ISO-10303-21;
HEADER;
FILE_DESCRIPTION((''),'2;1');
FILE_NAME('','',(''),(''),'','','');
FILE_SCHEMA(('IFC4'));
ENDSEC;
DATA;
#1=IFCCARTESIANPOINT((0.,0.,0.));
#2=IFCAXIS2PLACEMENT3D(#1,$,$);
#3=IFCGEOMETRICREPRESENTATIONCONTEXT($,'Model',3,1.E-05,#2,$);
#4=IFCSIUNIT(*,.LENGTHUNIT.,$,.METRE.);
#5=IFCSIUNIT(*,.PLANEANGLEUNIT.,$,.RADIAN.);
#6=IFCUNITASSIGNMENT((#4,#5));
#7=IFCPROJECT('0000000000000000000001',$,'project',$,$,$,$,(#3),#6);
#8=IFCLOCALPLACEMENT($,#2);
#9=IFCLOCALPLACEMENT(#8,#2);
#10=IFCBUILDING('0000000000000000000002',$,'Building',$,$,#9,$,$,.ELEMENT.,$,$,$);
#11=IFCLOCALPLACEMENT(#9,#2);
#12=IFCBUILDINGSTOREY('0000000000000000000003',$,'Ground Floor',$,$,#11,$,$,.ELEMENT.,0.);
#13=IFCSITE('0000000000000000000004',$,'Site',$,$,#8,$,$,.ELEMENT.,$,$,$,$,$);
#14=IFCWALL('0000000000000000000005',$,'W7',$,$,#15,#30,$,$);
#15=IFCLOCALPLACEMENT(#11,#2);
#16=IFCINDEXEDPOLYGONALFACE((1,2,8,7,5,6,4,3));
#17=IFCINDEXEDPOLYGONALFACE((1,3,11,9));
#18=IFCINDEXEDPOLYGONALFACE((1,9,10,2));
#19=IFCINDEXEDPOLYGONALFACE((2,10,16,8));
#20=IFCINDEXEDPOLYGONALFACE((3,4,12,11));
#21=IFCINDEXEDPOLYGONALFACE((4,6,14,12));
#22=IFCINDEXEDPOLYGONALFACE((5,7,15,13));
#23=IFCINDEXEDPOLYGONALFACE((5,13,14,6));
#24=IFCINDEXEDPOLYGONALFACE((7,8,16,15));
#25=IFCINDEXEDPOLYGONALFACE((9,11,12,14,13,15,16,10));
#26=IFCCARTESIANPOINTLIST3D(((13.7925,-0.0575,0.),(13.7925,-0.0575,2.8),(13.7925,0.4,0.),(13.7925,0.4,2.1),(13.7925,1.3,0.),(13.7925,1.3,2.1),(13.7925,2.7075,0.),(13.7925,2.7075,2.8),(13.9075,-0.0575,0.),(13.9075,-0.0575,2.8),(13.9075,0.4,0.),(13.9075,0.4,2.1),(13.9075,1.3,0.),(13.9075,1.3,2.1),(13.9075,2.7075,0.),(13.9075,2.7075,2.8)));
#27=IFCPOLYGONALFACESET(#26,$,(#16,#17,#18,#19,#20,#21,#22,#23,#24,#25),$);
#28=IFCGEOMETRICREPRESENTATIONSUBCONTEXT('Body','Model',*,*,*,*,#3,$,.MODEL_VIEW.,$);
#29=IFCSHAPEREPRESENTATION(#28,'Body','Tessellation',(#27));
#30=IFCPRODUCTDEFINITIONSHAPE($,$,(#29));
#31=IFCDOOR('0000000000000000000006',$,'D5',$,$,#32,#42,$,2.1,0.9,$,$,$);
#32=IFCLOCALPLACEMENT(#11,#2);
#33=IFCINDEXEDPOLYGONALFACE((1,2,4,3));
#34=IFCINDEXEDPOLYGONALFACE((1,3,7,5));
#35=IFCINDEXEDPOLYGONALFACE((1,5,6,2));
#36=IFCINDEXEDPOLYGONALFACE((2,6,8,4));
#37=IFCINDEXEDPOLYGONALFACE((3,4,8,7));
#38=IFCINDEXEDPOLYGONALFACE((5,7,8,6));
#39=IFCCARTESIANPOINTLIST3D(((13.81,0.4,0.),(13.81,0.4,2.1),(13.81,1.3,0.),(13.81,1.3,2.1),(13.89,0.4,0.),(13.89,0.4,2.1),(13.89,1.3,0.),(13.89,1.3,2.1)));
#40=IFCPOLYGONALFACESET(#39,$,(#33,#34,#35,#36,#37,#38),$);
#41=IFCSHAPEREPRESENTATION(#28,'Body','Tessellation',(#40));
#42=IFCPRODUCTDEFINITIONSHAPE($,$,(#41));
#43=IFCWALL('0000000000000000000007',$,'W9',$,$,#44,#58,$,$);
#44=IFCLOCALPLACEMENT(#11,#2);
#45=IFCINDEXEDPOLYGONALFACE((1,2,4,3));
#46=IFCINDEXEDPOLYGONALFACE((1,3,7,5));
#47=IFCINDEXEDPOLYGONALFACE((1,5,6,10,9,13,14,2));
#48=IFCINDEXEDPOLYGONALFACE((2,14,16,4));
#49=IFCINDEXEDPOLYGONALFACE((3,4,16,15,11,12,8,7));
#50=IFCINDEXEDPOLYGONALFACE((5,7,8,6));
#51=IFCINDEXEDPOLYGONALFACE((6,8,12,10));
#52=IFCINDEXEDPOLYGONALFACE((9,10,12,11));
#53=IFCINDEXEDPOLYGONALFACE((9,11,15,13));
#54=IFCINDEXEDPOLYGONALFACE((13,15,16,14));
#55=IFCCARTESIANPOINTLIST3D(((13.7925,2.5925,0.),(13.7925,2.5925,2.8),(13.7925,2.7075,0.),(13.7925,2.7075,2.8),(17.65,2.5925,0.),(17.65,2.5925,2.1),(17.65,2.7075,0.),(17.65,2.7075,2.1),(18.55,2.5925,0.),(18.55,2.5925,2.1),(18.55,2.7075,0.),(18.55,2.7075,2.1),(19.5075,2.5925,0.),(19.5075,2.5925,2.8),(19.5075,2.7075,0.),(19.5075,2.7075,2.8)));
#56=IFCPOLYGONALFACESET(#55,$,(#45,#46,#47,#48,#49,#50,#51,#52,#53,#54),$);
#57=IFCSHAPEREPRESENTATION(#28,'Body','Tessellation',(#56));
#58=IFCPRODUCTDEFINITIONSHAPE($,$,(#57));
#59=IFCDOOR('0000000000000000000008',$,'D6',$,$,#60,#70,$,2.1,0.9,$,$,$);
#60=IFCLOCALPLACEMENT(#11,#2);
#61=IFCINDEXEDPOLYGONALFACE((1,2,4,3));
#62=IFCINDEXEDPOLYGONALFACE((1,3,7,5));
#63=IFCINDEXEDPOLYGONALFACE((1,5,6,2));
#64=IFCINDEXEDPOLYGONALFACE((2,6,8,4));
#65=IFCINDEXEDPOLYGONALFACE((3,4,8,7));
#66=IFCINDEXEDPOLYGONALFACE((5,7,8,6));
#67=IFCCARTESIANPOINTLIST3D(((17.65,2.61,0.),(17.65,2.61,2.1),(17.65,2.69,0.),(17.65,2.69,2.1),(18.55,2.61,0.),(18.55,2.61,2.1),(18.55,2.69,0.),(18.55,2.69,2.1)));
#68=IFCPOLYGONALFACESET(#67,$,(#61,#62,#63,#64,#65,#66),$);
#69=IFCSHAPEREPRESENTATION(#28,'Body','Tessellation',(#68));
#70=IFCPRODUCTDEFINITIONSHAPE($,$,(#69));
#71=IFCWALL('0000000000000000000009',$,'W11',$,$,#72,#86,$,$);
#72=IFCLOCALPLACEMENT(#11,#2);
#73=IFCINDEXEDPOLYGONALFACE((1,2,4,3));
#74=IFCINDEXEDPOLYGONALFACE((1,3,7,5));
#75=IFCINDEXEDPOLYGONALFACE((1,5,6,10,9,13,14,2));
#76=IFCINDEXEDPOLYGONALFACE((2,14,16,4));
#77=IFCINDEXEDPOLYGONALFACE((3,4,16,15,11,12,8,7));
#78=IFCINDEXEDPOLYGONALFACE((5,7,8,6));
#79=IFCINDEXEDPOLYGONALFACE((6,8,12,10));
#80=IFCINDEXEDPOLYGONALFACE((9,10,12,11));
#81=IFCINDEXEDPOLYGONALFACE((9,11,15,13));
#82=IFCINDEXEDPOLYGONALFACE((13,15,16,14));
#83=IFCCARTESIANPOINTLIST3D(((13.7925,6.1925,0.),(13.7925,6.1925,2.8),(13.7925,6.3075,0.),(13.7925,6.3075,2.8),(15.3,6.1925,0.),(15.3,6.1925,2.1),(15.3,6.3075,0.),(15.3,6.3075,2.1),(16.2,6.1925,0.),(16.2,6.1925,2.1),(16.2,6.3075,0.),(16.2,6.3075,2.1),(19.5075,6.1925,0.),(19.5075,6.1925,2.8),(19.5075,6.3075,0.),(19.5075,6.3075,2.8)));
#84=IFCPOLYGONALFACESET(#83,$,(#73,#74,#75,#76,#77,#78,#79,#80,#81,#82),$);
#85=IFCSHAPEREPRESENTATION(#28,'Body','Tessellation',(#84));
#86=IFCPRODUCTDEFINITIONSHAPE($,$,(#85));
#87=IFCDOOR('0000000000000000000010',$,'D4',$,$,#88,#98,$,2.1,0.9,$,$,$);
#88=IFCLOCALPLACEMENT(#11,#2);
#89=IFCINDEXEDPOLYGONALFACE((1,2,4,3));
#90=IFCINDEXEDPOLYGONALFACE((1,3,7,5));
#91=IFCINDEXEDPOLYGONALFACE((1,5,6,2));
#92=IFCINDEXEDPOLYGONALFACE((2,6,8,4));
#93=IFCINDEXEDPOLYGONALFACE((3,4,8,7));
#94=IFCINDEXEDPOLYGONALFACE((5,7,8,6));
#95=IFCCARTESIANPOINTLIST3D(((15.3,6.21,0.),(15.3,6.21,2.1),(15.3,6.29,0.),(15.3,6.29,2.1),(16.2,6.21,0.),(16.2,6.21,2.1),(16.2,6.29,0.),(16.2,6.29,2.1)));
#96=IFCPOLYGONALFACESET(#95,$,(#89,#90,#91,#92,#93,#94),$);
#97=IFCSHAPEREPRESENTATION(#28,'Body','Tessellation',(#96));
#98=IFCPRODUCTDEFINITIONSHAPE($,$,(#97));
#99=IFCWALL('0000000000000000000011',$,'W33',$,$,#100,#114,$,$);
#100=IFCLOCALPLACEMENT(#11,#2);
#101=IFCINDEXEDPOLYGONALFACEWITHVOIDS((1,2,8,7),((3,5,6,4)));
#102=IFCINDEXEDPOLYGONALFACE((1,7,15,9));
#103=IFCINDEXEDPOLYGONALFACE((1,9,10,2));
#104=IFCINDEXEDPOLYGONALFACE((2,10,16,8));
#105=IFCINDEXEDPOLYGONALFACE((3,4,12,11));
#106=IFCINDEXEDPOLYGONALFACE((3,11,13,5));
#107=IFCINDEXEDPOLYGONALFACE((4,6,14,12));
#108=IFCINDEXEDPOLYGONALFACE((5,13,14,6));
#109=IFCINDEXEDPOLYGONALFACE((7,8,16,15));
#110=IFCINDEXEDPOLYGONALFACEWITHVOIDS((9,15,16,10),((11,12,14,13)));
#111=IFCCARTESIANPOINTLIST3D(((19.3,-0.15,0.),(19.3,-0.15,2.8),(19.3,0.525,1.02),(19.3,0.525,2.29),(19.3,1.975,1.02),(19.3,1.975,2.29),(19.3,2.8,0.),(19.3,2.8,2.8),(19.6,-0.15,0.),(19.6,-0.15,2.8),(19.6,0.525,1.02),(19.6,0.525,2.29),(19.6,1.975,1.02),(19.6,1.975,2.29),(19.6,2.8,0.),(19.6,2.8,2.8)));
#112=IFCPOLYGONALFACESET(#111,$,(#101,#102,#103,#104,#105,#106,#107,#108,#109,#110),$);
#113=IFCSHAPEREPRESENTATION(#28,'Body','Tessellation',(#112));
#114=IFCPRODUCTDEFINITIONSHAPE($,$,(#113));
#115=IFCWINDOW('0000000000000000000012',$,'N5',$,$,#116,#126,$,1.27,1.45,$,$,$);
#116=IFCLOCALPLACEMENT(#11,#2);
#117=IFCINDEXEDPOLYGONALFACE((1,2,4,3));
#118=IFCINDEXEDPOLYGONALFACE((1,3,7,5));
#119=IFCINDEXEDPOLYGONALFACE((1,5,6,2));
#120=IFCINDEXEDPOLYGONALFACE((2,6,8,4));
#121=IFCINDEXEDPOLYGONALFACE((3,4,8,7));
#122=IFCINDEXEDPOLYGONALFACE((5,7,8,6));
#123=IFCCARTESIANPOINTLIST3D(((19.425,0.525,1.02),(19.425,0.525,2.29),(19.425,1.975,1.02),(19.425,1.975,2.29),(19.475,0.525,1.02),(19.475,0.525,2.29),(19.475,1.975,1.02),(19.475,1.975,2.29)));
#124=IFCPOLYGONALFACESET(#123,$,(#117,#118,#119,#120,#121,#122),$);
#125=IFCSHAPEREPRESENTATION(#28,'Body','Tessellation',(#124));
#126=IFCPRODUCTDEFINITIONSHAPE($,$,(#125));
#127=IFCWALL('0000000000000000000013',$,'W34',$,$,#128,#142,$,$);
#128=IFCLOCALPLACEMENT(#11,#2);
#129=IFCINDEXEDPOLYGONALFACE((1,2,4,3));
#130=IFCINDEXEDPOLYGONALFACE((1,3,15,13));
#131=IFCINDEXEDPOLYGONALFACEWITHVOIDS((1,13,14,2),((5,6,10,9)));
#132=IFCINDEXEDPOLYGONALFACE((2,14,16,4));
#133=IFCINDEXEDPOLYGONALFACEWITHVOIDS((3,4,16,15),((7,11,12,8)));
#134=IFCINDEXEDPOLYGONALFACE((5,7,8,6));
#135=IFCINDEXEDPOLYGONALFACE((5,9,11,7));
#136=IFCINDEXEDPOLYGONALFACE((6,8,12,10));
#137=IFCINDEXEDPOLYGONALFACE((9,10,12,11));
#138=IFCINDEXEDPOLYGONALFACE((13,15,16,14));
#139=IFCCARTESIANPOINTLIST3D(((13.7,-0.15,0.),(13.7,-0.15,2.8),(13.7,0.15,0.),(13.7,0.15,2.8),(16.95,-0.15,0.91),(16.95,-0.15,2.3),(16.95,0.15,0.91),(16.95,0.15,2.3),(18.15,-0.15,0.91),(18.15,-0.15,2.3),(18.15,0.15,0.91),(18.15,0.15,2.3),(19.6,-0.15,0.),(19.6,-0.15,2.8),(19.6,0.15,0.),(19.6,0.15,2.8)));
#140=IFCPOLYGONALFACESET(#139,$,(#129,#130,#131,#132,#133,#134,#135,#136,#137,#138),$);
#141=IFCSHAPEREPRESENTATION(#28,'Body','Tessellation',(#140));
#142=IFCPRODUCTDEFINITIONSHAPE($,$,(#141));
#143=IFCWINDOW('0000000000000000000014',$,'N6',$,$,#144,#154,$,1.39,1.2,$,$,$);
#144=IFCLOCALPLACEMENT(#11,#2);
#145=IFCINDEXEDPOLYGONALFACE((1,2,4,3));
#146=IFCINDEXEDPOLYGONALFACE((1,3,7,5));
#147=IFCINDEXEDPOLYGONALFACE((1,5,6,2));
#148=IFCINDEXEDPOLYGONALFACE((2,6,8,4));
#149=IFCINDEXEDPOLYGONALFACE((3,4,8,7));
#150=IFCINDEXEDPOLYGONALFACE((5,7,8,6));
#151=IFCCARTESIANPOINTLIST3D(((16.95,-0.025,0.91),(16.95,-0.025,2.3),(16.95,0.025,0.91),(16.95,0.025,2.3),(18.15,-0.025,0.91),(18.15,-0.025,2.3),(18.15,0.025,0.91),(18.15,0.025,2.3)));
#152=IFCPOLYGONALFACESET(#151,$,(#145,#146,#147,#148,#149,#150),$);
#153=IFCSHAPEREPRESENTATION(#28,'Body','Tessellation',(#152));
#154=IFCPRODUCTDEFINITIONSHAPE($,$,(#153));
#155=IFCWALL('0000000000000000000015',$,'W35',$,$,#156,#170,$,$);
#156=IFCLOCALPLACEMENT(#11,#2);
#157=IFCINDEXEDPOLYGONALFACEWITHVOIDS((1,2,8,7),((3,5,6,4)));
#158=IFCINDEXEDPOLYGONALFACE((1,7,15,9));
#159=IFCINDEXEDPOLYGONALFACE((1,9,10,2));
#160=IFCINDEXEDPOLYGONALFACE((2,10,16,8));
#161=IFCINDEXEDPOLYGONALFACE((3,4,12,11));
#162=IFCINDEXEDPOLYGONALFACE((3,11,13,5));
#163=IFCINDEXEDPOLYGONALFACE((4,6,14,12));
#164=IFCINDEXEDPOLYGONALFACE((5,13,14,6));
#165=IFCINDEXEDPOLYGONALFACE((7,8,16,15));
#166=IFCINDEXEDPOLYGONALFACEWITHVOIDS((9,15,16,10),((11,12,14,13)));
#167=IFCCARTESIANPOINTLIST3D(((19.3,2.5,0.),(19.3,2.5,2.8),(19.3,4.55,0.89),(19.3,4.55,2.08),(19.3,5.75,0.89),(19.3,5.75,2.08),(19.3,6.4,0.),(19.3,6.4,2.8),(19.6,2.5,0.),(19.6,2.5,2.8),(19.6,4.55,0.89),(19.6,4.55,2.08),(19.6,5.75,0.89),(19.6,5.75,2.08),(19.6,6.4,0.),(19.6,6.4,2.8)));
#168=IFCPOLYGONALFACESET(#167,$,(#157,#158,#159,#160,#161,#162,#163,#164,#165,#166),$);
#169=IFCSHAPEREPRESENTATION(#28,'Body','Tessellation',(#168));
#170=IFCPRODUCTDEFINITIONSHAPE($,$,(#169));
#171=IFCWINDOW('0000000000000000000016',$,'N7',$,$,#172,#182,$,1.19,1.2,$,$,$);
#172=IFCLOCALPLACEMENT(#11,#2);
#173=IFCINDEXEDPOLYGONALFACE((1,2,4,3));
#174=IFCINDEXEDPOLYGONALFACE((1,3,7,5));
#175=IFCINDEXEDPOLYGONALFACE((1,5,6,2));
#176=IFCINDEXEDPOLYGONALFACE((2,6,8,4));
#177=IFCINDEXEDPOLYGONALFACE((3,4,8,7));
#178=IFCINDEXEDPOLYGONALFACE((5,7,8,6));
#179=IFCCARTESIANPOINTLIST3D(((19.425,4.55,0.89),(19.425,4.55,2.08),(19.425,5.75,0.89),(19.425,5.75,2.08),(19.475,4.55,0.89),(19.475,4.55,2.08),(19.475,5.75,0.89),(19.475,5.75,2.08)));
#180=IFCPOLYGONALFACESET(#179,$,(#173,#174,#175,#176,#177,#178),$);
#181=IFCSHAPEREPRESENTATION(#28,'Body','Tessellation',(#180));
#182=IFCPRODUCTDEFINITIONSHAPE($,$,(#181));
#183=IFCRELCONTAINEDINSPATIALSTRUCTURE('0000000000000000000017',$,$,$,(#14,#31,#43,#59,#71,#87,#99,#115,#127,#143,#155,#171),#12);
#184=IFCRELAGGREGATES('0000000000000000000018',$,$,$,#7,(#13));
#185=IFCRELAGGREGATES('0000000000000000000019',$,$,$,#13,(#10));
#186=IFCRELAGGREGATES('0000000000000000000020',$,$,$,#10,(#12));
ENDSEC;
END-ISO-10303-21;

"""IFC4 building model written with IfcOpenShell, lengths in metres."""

from ifc_helpers import new_model, si_unit, frame, frame_2d, origin, origin_2d, place, context, subcontext, project, spatial, rectangle, extrude, element, fill, save


model = new_model("IFC4")

# Units and contexts
model_context = context("Model", 3, precision=1e-05, world=origin())
body_context = subcontext(model_context, "Body", "Model", "MODEL_VIEW")
ifc_project = project(units=[si_unit("LENGTHUNIT", "METRE"), si_unit("PLANEANGLEUNIT", "RADIAN")], contexts=[model_context])

# Site, building, storey
site_placement = place(None, origin())
site = spatial("IfcSite", under=ifc_project, at=site_placement, Name="Site", CompositionType="ELEMENT")
building_placement = place(site_placement, origin())
building = spatial("IfcBuilding", under=site, at=building_placement, Name="Building", CompositionType="ELEMENT")
storey_placement = place(building_placement, origin())
storey = spatial("IfcBuildingStorey", under=building, at=storey_placement, Name="Ground Floor", CompositionType="ELEMENT", Elevation=0.0)

# Walls, openings, doors
wall_1_placement = place(storey_placement, frame((13.85, 0.0, 0.0), x_axis=(0.0, 1.0, 0.0)))
wall_1 = element("IfcWall", 1, at=wall_1_placement, inside=storey, Name="W7", context=body_context, shape_type="SweptSolid", body=[
    extrude(rectangle(XDim=2.765, YDim=0.115, at=frame_2d((1.325, 0.0))), origin(), (0.0, 0.0, 1.0), 2.8),
])
opening_1_placement = place(wall_1_placement, frame((0.85, 0.0, 0.0)))
opening_1 = element("IfcOpeningElement", 2, at=opening_1_placement, cuts=wall_1, context=body_context, shape_type="SweptSolid", body=[
    extrude(rectangle(XDim=0.9, YDim=0.215, at=origin_2d()), origin(), (0.0, 0.0, 1.0), 2.1),
])
door_1_placement = place(opening_1_placement, origin())
door_1 = element("IfcDoor", 3, at=door_1_placement, inside=storey, Name="D5", OverallHeight=2.1, OverallWidth=0.9, context=body_context, shape_type="SweptSolid", body=[
    extrude(rectangle(XDim=0.9, YDim=0.08, at=origin_2d()), origin(), (0.0, 0.0, 1.0), 2.1),
])
fill(opening_1, door_1)
wall_2_placement = place(storey_placement, frame((13.85, 2.65, 0.0), x_axis=(1.0, 0.0, 0.0)))
wall_2 = element("IfcWall", 4, at=wall_2_placement, inside=storey, Name="W9", context=body_context, shape_type="SweptSolid", body=[
    extrude(rectangle(XDim=5.715, YDim=0.115, at=frame_2d((2.8, 0.0))), origin(), (0.0, 0.0, 1.0), 2.8),
])
opening_2_placement = place(wall_2_placement, frame((4.25, 0.0, 0.0)))
opening_2 = element("IfcOpeningElement", 5, at=opening_2_placement, cuts=wall_2, context=body_context, shape_type="SweptSolid", body=[
    extrude(rectangle(XDim=0.9, YDim=0.215, at=origin_2d()), origin(), (0.0, 0.0, 1.0), 2.1),
])
door_2_placement = place(opening_2_placement, origin())
door_2 = element("IfcDoor", 6, at=door_2_placement, inside=storey, Name="D6", OverallHeight=2.1, OverallWidth=0.9, context=body_context, shape_type="SweptSolid", body=[
    extrude(rectangle(XDim=0.9, YDim=0.08, at=origin_2d()), origin(), (0.0, 0.0, 1.0), 2.1),
])
fill(opening_2, door_2)

# Wall, opening, door
wall_3_placement = place(storey_placement, frame((13.85, 6.25, 0.0), x_axis=(1.0, 0.0, 0.0)))
wall_3 = element("IfcWall", 7, at=wall_3_placement, inside=storey, Name="W11", context=body_context, shape_type="SweptSolid", body=[
    extrude(rectangle(XDim=5.715, YDim=0.115, at=frame_2d((2.8, 0.0))), origin(), (0.0, 0.0, 1.0), 2.8),
])
opening_3_placement = place(wall_3_placement, frame((1.9, 0.0, 0.0)))
opening_3 = element("IfcOpeningElement", 8, at=opening_3_placement, cuts=wall_3, context=body_context, shape_type="SweptSolid", body=[
    extrude(rectangle(XDim=0.9, YDim=0.215, at=origin_2d()), origin(), (0.0, 0.0, 1.0), 2.1),
])
door_3_placement = place(opening_3_placement, origin())
door_3 = element("IfcDoor", 9, at=door_3_placement, inside=storey, Name="D4", OverallHeight=2.1, OverallWidth=0.9, context=body_context, shape_type="SweptSolid", body=[
    extrude(rectangle(XDim=0.9, YDim=0.08, at=origin_2d()), origin(), (0.0, 0.0, 1.0), 2.1),
])
fill(opening_3, door_3)

# Walls, openings, windows
wall_4_placement = place(storey_placement, frame((19.45, 0.0, 0.0), x_axis=(0.0, 1.0, 0.0)))
wall_4 = element("IfcWall", 10, at=wall_4_placement, inside=storey, Name="W33", context=body_context, shape_type="SweptSolid", body=[
    extrude(rectangle(XDim=2.95, YDim=0.3, at=frame_2d((1.325, 0.0))), origin(), (0.0, 0.0, 1.0), 2.8),
])
opening_4_placement = place(wall_4_placement, frame((1.25, 0.0, 1.02)))
opening_4 = element("IfcOpeningElement", 11, at=opening_4_placement, cuts=wall_4, context=body_context, shape_type="SweptSolid", body=[
    extrude(rectangle(XDim=1.45, YDim=0.4, at=origin_2d()), origin(), (0.0, 0.0, 1.0), 1.27),
])
window_1_placement = place(opening_4_placement, origin())
window_1 = element("IfcWindow", 12, at=window_1_placement, inside=storey, Name="N5", OverallHeight=1.27, OverallWidth=1.45, context=body_context, shape_type="SweptSolid", body=[
    extrude(rectangle(XDim=1.45, YDim=0.05, at=origin_2d()), origin(), (0.0, 0.0, 1.0), 1.27),
])
fill(opening_4, window_1)
wall_5_placement = place(storey_placement, frame((13.85, 0.0, 0.0), x_axis=(1.0, 0.0, 0.0)))
wall_5 = element("IfcWall", 13, at=wall_5_placement, inside=storey, Name="W34", context=body_context, shape_type="SweptSolid", body=[
    extrude(rectangle(XDim=5.9, YDim=0.3, at=frame_2d((2.8, 0.0))), origin(), (0.0, 0.0, 1.0), 2.8),
])
opening_5_placement = place(wall_5_placement, frame((3.7, 0.0, 0.91)))
opening_5 = element("IfcOpeningElement", 14, at=opening_5_placement, cuts=wall_5, context=body_context, shape_type="SweptSolid", body=[
    extrude(rectangle(XDim=1.2, YDim=0.4, at=origin_2d()), origin(), (0.0, 0.0, 1.0), 1.39),
])
window_2_placement = place(opening_5_placement, origin())
window_2 = element("IfcWindow", 15, at=window_2_placement, inside=storey, Name="N6", OverallHeight=1.39, OverallWidth=1.2, context=body_context, shape_type="SweptSolid", body=[
    extrude(rectangle(XDim=1.2, YDim=0.05, at=origin_2d()), origin(), (0.0, 0.0, 1.0), 1.39),
])
fill(opening_5, window_2)
wall_6_placement = place(storey_placement, frame((19.45, 2.65, 0.0), x_axis=(0.0, 1.0, 0.0)))
wall_6 = element("IfcWall", 16, at=wall_6_placement, inside=storey, Name="W35", context=body_context, shape_type="SweptSolid", body=[
    extrude(rectangle(XDim=3.9, YDim=0.3, at=frame_2d((1.8, 0.0))), origin(), (0.0, 0.0, 1.0), 2.8),
])
opening_6_placement = place(wall_6_placement, frame((2.5, 0.0, 0.89)))
opening_6 = element("IfcOpeningElement", 17, at=opening_6_placement, cuts=wall_6, context=body_context, shape_type="SweptSolid", body=[
    extrude(rectangle(XDim=1.2, YDim=0.4, at=origin_2d()), origin(), (0.0, 0.0, 1.0), 1.19),
])
window_3_placement = place(opening_6_placement, origin())
window_3 = element("IfcWindow", 18, at=window_3_placement, inside=storey, Name="N7", OverallHeight=1.19, OverallWidth=1.2, context=body_context, shape_type="SweptSolid", body=[
    extrude(rectangle(XDim=1.2, YDim=0.05, at=origin_2d()), origin(), (0.0, 0.0, 1.0), 1.19),
])
fill(opening_6, window_3)

save(model, "model.ifc")
